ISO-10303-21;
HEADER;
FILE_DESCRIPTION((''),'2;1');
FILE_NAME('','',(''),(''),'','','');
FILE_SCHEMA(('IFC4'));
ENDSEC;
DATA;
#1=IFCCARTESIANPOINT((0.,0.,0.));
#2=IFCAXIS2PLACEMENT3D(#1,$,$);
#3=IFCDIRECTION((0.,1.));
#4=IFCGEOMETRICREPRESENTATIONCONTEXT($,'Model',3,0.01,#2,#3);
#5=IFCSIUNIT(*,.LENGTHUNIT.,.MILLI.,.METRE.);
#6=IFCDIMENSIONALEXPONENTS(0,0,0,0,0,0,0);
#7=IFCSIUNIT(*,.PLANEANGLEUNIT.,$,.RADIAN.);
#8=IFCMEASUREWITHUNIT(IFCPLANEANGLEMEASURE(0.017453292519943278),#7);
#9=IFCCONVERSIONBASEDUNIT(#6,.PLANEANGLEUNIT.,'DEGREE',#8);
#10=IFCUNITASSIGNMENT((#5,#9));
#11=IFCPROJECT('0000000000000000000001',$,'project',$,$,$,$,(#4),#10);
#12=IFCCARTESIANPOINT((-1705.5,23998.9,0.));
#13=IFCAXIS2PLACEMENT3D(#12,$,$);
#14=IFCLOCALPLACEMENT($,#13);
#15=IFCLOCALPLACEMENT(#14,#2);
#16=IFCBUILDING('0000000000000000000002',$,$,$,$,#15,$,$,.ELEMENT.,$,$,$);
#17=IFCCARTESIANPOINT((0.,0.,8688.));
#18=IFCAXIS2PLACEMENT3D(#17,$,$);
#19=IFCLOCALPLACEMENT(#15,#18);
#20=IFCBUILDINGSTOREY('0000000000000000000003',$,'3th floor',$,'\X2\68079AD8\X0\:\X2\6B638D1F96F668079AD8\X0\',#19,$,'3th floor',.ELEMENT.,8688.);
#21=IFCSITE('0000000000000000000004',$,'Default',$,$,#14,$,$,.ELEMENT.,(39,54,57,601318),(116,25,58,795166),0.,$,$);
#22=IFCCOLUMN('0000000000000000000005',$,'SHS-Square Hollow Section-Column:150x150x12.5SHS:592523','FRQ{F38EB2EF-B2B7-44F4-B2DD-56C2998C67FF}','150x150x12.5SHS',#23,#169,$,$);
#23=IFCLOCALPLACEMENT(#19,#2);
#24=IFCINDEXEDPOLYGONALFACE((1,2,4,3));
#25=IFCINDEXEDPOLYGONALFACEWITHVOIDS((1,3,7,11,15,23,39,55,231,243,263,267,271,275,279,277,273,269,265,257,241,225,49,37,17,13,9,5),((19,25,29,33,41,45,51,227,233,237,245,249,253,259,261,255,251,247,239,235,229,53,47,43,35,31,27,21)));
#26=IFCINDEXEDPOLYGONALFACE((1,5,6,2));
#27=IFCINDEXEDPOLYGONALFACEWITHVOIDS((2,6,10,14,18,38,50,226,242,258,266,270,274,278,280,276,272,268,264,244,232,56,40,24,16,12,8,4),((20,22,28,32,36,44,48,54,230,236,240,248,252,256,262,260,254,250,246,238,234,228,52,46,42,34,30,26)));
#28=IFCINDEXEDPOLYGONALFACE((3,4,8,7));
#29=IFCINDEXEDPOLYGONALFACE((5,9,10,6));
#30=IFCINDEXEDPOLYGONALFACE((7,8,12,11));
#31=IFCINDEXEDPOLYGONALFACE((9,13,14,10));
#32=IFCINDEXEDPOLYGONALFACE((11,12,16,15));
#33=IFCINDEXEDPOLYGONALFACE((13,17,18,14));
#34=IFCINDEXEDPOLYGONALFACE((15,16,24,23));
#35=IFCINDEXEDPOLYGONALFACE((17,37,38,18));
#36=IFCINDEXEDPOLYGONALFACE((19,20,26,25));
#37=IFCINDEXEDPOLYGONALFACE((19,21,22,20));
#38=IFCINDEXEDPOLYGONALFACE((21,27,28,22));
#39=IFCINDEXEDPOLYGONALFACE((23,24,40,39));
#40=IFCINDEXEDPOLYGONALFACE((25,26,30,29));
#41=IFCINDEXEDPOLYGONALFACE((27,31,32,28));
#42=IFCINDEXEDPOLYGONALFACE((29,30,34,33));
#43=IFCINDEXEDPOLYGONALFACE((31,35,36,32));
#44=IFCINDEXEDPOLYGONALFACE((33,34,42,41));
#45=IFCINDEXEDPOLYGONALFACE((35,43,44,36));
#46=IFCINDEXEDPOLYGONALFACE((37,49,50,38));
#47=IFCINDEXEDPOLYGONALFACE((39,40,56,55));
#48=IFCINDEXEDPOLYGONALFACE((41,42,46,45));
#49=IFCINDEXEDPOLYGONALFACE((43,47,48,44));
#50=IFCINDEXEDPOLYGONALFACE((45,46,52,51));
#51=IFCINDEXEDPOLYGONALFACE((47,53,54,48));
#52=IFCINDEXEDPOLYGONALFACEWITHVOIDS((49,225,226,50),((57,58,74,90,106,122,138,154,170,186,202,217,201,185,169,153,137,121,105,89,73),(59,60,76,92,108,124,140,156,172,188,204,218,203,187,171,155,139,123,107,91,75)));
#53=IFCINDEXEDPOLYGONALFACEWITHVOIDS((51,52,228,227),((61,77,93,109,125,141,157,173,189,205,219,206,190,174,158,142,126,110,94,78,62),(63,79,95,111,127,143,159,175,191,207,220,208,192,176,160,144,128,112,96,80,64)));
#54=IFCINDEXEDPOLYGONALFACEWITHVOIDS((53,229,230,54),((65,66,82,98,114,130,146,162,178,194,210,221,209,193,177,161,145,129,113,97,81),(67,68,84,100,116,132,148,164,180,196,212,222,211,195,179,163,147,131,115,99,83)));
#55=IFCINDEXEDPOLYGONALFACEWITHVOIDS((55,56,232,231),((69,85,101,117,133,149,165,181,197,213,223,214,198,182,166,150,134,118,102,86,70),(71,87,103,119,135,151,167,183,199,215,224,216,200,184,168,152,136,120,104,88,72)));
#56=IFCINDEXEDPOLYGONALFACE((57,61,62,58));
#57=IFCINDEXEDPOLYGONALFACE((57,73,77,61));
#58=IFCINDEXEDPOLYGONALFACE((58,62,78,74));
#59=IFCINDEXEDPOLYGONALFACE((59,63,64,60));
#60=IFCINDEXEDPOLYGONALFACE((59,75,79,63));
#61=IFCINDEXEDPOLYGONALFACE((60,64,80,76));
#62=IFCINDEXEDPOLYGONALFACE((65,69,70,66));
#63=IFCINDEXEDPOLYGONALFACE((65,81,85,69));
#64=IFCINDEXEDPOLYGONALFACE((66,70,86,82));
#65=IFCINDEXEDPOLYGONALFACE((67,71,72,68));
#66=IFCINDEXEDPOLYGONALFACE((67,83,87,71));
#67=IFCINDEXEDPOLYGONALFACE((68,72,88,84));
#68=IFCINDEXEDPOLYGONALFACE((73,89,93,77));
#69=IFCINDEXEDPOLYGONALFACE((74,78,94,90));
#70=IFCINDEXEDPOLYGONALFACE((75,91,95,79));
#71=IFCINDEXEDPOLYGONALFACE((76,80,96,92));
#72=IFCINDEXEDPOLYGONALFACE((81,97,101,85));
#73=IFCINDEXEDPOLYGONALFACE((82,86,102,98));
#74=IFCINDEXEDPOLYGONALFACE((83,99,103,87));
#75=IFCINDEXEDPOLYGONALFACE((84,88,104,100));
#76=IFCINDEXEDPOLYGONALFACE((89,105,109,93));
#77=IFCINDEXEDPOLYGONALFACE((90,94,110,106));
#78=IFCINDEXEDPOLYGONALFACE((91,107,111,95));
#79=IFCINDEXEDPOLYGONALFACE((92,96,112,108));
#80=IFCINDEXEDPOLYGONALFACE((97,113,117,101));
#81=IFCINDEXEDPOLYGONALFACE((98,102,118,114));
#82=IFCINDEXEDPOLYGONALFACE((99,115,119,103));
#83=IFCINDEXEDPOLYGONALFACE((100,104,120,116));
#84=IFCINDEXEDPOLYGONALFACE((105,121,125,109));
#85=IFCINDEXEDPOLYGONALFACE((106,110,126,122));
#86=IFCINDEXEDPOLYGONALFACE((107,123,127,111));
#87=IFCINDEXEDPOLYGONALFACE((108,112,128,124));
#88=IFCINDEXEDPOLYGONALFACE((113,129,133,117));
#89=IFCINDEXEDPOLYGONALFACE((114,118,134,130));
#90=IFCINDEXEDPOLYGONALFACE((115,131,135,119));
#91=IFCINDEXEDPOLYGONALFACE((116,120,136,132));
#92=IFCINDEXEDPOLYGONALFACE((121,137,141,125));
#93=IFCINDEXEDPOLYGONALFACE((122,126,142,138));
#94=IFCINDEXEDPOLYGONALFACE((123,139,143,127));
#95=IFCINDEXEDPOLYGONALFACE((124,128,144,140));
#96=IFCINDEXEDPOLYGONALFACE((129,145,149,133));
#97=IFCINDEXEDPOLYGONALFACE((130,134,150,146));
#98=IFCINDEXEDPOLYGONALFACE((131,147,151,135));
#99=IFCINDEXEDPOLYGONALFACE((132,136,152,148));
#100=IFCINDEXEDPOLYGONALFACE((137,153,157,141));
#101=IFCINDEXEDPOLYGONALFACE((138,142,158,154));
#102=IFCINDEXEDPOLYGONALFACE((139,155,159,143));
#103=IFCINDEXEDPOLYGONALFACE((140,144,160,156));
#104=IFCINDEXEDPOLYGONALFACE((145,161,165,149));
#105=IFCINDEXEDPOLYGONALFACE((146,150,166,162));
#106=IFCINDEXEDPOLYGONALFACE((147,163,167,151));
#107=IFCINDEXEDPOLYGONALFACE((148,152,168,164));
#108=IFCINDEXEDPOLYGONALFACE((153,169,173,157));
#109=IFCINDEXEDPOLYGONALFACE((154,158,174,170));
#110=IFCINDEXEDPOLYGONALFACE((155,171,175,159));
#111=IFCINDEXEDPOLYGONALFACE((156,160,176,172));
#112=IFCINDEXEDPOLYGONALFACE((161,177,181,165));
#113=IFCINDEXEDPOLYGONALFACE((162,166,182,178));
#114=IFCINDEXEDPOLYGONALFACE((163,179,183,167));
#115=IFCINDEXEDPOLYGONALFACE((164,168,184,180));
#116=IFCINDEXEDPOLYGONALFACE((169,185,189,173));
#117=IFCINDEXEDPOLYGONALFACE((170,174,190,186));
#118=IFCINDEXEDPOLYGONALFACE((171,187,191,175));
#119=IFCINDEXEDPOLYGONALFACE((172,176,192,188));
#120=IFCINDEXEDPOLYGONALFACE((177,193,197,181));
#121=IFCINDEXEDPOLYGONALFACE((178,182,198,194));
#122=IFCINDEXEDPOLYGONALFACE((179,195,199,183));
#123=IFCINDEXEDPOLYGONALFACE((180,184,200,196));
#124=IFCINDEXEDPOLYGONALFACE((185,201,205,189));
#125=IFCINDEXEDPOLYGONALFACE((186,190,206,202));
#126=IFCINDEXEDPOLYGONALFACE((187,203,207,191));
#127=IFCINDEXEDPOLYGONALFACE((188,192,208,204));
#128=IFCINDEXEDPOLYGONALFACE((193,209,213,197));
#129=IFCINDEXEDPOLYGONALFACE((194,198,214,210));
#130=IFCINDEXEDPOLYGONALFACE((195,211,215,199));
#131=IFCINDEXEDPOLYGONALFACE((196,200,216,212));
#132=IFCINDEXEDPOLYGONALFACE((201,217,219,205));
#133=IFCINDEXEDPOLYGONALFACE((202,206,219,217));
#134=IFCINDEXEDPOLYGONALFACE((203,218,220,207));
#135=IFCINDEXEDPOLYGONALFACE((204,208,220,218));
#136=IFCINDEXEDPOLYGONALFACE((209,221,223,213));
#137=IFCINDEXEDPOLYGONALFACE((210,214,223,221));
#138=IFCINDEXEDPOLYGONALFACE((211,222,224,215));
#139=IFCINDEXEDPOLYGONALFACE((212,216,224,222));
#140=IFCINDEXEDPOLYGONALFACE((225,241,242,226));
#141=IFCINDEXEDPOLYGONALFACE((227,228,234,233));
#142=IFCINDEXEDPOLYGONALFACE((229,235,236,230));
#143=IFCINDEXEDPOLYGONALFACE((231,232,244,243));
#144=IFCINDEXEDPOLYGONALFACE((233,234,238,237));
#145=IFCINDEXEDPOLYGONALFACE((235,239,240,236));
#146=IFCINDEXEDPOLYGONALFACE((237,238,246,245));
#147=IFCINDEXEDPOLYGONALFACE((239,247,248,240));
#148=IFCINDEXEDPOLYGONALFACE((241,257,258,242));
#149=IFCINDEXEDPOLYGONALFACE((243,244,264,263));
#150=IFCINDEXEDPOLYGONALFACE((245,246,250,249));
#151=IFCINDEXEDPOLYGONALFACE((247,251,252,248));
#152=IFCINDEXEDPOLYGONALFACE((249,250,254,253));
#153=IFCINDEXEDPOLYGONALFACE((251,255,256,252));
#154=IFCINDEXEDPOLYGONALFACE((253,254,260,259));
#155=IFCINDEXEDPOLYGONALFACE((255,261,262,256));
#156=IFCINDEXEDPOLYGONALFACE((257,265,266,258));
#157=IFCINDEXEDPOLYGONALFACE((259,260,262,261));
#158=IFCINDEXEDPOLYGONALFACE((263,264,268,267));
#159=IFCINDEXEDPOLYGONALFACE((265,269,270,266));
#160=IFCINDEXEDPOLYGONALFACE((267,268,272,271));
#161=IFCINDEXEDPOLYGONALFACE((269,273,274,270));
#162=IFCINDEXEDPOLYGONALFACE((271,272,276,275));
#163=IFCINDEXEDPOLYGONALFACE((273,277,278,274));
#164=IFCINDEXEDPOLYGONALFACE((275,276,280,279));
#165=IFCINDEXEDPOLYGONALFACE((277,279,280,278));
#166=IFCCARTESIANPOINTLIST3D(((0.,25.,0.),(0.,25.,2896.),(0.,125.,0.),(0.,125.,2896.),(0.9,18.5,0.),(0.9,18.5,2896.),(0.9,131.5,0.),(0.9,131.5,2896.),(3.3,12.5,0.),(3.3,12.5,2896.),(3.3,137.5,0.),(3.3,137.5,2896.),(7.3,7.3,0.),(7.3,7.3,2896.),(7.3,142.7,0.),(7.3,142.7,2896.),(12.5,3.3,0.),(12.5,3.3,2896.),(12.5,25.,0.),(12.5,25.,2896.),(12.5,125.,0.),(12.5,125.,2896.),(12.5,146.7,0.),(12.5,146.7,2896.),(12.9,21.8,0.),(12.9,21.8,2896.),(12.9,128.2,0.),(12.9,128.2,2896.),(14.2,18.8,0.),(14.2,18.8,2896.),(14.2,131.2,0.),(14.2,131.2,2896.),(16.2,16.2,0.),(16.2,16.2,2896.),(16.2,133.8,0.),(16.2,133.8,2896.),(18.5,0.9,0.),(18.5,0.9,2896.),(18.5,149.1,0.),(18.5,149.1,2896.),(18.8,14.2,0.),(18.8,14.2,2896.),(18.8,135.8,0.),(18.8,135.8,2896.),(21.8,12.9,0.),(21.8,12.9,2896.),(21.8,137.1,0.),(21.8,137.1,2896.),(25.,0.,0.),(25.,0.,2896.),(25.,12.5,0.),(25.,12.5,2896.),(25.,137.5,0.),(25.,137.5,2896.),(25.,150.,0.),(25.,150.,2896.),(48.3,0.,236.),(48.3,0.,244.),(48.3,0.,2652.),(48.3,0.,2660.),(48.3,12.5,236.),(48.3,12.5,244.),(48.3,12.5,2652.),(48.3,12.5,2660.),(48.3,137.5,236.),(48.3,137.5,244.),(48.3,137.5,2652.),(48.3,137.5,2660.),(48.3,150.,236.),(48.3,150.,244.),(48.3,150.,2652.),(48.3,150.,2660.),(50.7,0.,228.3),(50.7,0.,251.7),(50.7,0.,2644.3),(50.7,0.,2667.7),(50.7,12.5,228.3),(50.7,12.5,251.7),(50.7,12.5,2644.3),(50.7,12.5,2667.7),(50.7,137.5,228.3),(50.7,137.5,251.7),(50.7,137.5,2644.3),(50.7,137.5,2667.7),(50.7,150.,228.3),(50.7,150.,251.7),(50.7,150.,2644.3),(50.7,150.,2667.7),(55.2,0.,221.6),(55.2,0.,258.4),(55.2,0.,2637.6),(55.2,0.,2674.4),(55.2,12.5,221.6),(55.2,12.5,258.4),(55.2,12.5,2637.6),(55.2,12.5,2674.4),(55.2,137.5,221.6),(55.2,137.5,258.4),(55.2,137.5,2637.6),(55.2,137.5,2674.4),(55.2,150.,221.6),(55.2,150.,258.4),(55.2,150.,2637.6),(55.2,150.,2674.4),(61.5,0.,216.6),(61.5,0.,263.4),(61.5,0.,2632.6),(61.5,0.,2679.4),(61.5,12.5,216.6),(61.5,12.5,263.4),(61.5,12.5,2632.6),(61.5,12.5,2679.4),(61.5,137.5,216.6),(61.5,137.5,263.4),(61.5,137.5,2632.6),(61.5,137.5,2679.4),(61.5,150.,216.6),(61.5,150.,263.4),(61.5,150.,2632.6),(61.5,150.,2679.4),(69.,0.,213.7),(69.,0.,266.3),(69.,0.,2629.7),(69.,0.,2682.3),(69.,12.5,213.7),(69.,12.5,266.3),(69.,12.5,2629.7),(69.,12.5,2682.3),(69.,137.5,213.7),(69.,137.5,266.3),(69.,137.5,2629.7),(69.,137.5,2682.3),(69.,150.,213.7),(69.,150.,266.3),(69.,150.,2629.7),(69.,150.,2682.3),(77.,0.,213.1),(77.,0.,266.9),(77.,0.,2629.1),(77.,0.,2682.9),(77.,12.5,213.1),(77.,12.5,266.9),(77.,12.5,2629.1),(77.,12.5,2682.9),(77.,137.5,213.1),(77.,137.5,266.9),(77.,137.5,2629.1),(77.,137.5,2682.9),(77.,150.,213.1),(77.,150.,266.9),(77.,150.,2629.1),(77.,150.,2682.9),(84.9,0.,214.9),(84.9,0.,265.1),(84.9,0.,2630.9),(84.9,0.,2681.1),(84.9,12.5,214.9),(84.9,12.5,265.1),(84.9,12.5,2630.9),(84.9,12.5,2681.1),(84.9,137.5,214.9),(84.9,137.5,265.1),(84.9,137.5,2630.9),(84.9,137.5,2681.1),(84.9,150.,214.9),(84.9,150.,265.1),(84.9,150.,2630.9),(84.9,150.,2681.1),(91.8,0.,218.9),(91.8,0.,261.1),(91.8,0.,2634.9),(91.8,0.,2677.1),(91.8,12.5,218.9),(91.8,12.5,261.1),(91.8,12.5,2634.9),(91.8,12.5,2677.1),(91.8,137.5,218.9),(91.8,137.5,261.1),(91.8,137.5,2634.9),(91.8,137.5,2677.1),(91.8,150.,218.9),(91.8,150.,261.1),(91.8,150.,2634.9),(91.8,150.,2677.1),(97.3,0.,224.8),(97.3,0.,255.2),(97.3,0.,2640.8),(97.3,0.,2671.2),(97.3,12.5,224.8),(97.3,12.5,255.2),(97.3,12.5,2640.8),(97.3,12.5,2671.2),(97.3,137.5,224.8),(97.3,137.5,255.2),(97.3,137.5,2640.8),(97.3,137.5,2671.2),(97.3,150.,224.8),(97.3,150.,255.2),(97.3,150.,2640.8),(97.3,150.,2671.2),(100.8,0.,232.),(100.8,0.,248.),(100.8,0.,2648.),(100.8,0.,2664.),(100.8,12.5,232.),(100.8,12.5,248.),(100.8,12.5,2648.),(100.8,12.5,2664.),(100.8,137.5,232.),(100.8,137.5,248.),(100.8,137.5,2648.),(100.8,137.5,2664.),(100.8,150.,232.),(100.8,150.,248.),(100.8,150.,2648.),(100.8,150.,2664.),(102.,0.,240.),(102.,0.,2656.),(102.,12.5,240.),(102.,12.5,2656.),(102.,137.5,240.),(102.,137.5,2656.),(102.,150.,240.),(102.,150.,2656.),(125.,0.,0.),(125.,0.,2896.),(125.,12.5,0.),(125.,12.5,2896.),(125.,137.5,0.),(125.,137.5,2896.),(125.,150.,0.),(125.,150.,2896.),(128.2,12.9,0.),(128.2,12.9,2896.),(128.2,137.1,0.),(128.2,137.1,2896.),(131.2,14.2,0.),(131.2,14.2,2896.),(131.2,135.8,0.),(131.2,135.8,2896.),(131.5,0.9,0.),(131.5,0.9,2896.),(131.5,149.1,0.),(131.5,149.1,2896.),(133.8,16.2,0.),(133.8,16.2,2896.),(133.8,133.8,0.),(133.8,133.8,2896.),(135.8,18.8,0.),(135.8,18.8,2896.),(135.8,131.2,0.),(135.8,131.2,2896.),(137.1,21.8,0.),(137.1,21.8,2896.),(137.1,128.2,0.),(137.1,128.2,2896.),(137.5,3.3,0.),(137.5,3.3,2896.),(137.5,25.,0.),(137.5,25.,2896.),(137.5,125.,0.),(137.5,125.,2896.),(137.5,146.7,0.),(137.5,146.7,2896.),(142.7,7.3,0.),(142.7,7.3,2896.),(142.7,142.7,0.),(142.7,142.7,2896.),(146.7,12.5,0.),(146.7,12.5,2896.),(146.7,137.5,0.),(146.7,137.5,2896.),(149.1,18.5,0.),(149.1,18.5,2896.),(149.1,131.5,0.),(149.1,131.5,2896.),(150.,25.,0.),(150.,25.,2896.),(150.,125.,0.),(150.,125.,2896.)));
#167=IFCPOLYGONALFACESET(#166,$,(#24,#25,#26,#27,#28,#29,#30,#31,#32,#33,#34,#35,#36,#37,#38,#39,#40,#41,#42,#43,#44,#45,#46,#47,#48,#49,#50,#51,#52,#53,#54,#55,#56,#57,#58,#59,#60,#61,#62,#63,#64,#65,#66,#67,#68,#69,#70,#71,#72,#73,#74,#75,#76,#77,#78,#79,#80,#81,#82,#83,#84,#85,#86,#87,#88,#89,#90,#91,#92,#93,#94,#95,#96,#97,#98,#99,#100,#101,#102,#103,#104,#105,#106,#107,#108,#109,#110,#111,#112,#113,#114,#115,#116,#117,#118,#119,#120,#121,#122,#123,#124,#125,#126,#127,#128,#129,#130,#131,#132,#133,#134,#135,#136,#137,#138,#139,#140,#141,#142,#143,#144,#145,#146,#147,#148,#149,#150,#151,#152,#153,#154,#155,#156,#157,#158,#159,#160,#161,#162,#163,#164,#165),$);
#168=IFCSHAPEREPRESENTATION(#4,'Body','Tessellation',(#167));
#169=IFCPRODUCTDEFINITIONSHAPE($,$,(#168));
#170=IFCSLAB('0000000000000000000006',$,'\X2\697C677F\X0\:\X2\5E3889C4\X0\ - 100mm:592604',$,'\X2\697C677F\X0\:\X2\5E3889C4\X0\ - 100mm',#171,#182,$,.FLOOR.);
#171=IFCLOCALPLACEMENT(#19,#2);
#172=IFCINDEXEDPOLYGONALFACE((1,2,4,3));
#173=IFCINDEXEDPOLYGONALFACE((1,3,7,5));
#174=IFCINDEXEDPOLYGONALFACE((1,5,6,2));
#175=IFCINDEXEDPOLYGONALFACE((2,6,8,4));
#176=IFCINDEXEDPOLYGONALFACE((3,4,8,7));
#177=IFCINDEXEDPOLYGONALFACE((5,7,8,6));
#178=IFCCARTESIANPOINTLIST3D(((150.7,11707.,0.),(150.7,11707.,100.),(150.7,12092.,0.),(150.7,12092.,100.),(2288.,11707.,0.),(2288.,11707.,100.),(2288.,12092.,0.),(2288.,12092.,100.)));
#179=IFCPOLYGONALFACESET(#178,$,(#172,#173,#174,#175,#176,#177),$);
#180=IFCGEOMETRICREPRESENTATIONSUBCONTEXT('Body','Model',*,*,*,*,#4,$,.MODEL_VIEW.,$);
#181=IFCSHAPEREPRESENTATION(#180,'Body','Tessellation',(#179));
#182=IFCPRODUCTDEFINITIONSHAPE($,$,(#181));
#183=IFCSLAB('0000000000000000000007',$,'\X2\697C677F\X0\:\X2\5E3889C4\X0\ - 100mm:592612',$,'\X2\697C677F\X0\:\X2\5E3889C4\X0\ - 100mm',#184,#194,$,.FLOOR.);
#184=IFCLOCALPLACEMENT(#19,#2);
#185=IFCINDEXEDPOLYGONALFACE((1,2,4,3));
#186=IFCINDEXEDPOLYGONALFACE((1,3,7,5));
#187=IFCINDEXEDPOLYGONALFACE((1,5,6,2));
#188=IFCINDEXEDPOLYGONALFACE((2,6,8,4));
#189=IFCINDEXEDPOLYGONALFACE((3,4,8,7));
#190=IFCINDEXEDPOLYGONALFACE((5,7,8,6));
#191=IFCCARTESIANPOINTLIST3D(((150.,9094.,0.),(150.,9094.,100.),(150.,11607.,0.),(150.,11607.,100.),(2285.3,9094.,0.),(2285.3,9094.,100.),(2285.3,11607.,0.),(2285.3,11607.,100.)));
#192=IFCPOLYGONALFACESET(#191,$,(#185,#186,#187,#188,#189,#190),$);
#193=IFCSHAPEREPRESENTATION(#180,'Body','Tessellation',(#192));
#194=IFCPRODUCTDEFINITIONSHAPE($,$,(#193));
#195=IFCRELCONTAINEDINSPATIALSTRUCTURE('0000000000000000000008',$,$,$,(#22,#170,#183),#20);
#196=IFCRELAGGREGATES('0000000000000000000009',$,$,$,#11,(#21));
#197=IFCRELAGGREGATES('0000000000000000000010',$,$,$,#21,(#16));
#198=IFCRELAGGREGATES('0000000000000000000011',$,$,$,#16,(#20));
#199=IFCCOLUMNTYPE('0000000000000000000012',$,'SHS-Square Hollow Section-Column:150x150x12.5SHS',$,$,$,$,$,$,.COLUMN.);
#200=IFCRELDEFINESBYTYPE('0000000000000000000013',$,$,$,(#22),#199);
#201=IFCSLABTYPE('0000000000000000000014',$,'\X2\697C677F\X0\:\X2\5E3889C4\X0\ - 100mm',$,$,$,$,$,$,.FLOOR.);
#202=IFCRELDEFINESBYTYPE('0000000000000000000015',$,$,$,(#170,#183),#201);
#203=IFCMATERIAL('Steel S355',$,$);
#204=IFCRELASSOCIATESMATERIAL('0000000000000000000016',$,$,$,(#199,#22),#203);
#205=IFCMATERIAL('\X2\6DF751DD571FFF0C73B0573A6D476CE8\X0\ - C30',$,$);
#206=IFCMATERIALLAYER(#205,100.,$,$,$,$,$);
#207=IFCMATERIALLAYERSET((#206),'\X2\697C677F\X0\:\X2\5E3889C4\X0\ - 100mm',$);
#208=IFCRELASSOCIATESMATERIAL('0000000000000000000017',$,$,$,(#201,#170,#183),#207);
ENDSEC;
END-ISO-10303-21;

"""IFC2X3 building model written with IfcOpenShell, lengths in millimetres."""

from ifc_helpers import new_model, entity, si_unit, converted_unit, direction, frame, frame_2d, origin, origin_2d, origin_2d_with_axis, place, context, subcontext, project, spatial, circle_curve, rectangle, hollow_rectangle, outline, extrude, material, layer, layer_set, layer_usage, type_object, element, save


model = new_model("IFC2X3")

# Units and contexts
model_context = context("Model", 3, precision=0.01, world=origin(), true_north=direction((0.0, 1.0)))
body_context = subcontext(model_context, "Body", "Model", "MODEL_VIEW")
ifc_project = project(units=[si_unit("LENGTHUNIT", "METRE", prefix="MILLI"), converted_unit("PLANEANGLEUNIT", "DEGREE", entity("IfcPlaneAngleMeasure", 0.017453292519943278), si_unit("PLANEANGLEUNIT", "RADIAN"), dimensions=[0, 0, 0, 0, 0, 0, 0])], contexts=[model_context])

# Site, building, storey
site_placement = place(None, frame((-1705.5, 23998.9, 0.0)))
site = spatial("IfcSite", under=ifc_project, at=site_placement, Name="Default", CompositionType="ELEMENT", RefLatitude=(39, 54, 57, 601318), RefLongitude=(116, 25, 58, 795166), RefElevation=0.0)
building_placement = place(site_placement, origin())
building = spatial("IfcBuilding", under=site, at=building_placement, CompositionType="ELEMENT")
storey_placement = place(building_placement, frame((0.0, 0.0, 8688.0)))
storey = spatial("IfcBuildingStorey", under=building, at=storey_placement, Name="3th floor", ObjectType="标高:正负零标高", LongName="3th floor", CompositionType="ELEMENT", Elevation=8688.0)

# Shared definitions
ifc_material_1 = material(Name="Steel S355")

# Column, openings
column_type_1 = type_object("IfcColumnType", Name="SHS-Square Hollow Section-Column:150x150x12.5SHS", PredefinedType="COLUMN", material=ifc_material_1)
column_1_placement = place(storey_placement, frame((75.0, 75.0, 2896.0), z_axis=(0.0, 0.0, 1.0), x_axis=(0.0, -1.0, 0.0)))
column_1 = element("IfcColumn", 1, at=column_1_placement, inside=storey, type_object=column_type_1, material=ifc_material_1, Name="SHS-Square Hollow Section-Column:150x150x12.5SHS:592523", Description="FRQ{F38EB2EF-B2B7-44F4-B2DD-56C2998C67FF}", ObjectType="150x150x12.5SHS", context=model_context, shape_type="SweptSolid", body=[
    extrude(hollow_rectangle(XDim=150.0, YDim=150.0, WallThickness=12.5, InnerFilletRadius=12.5, OuterFilletRadius=25.0, at=origin_2d()), origin(), (0.0, 0.0, -1.0), 2896.0),
])
opening_1_placement = place(column_1_placement, frame((-175.1, 0.0, -2896.0), z_axis=(1.0, 0.0, 0.0), x_axis=(0.0, 1.0, 0.0)))
element("IfcOpeningElement", 2, at=opening_1_placement, cuts=column_1, ObjectType="Opening", context=model_context, shape_type="SweptSolid", body=[
    extrude(outline(circle_curve(frame_2d((0.0, 240.0), x_axis=(1.0, 0.0)), 27.0)), origin(), (0.0, 0.0, 1.0), 350.2),
])
opening_2_placement = place(column_1_placement, frame((-175.1, 0.0, 0.0), z_axis=(1.0, 0.0, 0.0), x_axis=(0.0, 1.0, 0.0)))
element("IfcOpeningElement", 3, at=opening_2_placement, cuts=column_1, ObjectType="Opening", context=model_context, shape_type="SweptSolid", body=[
    extrude(outline(circle_curve(frame_2d((0.0, -240.0), x_axis=(1.0, 0.0)), 27.0)), origin(), (0.0, 0.0, 1.0), 350.2),
])

# Slabs
ifc_material_2 = material(Name="混凝土，现场浇注 - C30")
ifc_layer_1 = layer(ifc_material_2, 100.0)
ifc_layer_set_1 = layer_set([ifc_layer_1], Name="楼板:常规 - 100mm")
ifc_layer_usage_1 = layer_usage(ifc_layer_set_1, "AXIS3", "POSITIVE", 0.0)
slab_type = type_object("IfcSlabType", Name="楼板:常规 - 100mm", PredefinedType="FLOOR", material=ifc_layer_set_1)
slab_1_placement = place(storey_placement, origin())
element("IfcSlab", 4, at=slab_1_placement, inside=storey, type_object=slab_type, material=ifc_layer_usage_1, Name="楼板:常规 - 100mm:592604", ObjectType="楼板:常规 - 100mm", PredefinedType="FLOOR", context=body_context, shape_type="SweptSolid", body=[
    extrude(rectangle(XDim=385.0, YDim=2137.3, at=origin_2d_with_axis()), frame((1219.3, 11899.5, 100.0), z_axis=(0.0, 0.0, -1.0), x_axis=(0.0, 1.0, 0.0)), (0.0, 0.0, 1.0), 100.0),
])
ifc_layer_usage_2 = layer_usage(ifc_layer_set_1, "AXIS3", "POSITIVE", 0.0)
slab_2_placement = place(storey_placement, origin())
element("IfcSlab", 5, at=slab_2_placement, inside=storey, type_object=slab_type, material=ifc_layer_usage_2, Name="楼板:常规 - 100mm:592612", ObjectType="楼板:常规 - 100mm", PredefinedType="FLOOR", context=body_context, shape_type="SweptSolid", body=[
    extrude(rectangle(XDim=2513.0, YDim=2135.3, at=frame_2d((0.0, 0.0), x_axis=(1.0, 0.0))), frame((1217.7, 10350.5, 100.0), z_axis=(0.0, 0.0, -1.0), x_axis=(0.0, 1.0, 0.0)), (0.0, 0.0, 1.0), 100.0),
])

save(model, "model.ifc")
